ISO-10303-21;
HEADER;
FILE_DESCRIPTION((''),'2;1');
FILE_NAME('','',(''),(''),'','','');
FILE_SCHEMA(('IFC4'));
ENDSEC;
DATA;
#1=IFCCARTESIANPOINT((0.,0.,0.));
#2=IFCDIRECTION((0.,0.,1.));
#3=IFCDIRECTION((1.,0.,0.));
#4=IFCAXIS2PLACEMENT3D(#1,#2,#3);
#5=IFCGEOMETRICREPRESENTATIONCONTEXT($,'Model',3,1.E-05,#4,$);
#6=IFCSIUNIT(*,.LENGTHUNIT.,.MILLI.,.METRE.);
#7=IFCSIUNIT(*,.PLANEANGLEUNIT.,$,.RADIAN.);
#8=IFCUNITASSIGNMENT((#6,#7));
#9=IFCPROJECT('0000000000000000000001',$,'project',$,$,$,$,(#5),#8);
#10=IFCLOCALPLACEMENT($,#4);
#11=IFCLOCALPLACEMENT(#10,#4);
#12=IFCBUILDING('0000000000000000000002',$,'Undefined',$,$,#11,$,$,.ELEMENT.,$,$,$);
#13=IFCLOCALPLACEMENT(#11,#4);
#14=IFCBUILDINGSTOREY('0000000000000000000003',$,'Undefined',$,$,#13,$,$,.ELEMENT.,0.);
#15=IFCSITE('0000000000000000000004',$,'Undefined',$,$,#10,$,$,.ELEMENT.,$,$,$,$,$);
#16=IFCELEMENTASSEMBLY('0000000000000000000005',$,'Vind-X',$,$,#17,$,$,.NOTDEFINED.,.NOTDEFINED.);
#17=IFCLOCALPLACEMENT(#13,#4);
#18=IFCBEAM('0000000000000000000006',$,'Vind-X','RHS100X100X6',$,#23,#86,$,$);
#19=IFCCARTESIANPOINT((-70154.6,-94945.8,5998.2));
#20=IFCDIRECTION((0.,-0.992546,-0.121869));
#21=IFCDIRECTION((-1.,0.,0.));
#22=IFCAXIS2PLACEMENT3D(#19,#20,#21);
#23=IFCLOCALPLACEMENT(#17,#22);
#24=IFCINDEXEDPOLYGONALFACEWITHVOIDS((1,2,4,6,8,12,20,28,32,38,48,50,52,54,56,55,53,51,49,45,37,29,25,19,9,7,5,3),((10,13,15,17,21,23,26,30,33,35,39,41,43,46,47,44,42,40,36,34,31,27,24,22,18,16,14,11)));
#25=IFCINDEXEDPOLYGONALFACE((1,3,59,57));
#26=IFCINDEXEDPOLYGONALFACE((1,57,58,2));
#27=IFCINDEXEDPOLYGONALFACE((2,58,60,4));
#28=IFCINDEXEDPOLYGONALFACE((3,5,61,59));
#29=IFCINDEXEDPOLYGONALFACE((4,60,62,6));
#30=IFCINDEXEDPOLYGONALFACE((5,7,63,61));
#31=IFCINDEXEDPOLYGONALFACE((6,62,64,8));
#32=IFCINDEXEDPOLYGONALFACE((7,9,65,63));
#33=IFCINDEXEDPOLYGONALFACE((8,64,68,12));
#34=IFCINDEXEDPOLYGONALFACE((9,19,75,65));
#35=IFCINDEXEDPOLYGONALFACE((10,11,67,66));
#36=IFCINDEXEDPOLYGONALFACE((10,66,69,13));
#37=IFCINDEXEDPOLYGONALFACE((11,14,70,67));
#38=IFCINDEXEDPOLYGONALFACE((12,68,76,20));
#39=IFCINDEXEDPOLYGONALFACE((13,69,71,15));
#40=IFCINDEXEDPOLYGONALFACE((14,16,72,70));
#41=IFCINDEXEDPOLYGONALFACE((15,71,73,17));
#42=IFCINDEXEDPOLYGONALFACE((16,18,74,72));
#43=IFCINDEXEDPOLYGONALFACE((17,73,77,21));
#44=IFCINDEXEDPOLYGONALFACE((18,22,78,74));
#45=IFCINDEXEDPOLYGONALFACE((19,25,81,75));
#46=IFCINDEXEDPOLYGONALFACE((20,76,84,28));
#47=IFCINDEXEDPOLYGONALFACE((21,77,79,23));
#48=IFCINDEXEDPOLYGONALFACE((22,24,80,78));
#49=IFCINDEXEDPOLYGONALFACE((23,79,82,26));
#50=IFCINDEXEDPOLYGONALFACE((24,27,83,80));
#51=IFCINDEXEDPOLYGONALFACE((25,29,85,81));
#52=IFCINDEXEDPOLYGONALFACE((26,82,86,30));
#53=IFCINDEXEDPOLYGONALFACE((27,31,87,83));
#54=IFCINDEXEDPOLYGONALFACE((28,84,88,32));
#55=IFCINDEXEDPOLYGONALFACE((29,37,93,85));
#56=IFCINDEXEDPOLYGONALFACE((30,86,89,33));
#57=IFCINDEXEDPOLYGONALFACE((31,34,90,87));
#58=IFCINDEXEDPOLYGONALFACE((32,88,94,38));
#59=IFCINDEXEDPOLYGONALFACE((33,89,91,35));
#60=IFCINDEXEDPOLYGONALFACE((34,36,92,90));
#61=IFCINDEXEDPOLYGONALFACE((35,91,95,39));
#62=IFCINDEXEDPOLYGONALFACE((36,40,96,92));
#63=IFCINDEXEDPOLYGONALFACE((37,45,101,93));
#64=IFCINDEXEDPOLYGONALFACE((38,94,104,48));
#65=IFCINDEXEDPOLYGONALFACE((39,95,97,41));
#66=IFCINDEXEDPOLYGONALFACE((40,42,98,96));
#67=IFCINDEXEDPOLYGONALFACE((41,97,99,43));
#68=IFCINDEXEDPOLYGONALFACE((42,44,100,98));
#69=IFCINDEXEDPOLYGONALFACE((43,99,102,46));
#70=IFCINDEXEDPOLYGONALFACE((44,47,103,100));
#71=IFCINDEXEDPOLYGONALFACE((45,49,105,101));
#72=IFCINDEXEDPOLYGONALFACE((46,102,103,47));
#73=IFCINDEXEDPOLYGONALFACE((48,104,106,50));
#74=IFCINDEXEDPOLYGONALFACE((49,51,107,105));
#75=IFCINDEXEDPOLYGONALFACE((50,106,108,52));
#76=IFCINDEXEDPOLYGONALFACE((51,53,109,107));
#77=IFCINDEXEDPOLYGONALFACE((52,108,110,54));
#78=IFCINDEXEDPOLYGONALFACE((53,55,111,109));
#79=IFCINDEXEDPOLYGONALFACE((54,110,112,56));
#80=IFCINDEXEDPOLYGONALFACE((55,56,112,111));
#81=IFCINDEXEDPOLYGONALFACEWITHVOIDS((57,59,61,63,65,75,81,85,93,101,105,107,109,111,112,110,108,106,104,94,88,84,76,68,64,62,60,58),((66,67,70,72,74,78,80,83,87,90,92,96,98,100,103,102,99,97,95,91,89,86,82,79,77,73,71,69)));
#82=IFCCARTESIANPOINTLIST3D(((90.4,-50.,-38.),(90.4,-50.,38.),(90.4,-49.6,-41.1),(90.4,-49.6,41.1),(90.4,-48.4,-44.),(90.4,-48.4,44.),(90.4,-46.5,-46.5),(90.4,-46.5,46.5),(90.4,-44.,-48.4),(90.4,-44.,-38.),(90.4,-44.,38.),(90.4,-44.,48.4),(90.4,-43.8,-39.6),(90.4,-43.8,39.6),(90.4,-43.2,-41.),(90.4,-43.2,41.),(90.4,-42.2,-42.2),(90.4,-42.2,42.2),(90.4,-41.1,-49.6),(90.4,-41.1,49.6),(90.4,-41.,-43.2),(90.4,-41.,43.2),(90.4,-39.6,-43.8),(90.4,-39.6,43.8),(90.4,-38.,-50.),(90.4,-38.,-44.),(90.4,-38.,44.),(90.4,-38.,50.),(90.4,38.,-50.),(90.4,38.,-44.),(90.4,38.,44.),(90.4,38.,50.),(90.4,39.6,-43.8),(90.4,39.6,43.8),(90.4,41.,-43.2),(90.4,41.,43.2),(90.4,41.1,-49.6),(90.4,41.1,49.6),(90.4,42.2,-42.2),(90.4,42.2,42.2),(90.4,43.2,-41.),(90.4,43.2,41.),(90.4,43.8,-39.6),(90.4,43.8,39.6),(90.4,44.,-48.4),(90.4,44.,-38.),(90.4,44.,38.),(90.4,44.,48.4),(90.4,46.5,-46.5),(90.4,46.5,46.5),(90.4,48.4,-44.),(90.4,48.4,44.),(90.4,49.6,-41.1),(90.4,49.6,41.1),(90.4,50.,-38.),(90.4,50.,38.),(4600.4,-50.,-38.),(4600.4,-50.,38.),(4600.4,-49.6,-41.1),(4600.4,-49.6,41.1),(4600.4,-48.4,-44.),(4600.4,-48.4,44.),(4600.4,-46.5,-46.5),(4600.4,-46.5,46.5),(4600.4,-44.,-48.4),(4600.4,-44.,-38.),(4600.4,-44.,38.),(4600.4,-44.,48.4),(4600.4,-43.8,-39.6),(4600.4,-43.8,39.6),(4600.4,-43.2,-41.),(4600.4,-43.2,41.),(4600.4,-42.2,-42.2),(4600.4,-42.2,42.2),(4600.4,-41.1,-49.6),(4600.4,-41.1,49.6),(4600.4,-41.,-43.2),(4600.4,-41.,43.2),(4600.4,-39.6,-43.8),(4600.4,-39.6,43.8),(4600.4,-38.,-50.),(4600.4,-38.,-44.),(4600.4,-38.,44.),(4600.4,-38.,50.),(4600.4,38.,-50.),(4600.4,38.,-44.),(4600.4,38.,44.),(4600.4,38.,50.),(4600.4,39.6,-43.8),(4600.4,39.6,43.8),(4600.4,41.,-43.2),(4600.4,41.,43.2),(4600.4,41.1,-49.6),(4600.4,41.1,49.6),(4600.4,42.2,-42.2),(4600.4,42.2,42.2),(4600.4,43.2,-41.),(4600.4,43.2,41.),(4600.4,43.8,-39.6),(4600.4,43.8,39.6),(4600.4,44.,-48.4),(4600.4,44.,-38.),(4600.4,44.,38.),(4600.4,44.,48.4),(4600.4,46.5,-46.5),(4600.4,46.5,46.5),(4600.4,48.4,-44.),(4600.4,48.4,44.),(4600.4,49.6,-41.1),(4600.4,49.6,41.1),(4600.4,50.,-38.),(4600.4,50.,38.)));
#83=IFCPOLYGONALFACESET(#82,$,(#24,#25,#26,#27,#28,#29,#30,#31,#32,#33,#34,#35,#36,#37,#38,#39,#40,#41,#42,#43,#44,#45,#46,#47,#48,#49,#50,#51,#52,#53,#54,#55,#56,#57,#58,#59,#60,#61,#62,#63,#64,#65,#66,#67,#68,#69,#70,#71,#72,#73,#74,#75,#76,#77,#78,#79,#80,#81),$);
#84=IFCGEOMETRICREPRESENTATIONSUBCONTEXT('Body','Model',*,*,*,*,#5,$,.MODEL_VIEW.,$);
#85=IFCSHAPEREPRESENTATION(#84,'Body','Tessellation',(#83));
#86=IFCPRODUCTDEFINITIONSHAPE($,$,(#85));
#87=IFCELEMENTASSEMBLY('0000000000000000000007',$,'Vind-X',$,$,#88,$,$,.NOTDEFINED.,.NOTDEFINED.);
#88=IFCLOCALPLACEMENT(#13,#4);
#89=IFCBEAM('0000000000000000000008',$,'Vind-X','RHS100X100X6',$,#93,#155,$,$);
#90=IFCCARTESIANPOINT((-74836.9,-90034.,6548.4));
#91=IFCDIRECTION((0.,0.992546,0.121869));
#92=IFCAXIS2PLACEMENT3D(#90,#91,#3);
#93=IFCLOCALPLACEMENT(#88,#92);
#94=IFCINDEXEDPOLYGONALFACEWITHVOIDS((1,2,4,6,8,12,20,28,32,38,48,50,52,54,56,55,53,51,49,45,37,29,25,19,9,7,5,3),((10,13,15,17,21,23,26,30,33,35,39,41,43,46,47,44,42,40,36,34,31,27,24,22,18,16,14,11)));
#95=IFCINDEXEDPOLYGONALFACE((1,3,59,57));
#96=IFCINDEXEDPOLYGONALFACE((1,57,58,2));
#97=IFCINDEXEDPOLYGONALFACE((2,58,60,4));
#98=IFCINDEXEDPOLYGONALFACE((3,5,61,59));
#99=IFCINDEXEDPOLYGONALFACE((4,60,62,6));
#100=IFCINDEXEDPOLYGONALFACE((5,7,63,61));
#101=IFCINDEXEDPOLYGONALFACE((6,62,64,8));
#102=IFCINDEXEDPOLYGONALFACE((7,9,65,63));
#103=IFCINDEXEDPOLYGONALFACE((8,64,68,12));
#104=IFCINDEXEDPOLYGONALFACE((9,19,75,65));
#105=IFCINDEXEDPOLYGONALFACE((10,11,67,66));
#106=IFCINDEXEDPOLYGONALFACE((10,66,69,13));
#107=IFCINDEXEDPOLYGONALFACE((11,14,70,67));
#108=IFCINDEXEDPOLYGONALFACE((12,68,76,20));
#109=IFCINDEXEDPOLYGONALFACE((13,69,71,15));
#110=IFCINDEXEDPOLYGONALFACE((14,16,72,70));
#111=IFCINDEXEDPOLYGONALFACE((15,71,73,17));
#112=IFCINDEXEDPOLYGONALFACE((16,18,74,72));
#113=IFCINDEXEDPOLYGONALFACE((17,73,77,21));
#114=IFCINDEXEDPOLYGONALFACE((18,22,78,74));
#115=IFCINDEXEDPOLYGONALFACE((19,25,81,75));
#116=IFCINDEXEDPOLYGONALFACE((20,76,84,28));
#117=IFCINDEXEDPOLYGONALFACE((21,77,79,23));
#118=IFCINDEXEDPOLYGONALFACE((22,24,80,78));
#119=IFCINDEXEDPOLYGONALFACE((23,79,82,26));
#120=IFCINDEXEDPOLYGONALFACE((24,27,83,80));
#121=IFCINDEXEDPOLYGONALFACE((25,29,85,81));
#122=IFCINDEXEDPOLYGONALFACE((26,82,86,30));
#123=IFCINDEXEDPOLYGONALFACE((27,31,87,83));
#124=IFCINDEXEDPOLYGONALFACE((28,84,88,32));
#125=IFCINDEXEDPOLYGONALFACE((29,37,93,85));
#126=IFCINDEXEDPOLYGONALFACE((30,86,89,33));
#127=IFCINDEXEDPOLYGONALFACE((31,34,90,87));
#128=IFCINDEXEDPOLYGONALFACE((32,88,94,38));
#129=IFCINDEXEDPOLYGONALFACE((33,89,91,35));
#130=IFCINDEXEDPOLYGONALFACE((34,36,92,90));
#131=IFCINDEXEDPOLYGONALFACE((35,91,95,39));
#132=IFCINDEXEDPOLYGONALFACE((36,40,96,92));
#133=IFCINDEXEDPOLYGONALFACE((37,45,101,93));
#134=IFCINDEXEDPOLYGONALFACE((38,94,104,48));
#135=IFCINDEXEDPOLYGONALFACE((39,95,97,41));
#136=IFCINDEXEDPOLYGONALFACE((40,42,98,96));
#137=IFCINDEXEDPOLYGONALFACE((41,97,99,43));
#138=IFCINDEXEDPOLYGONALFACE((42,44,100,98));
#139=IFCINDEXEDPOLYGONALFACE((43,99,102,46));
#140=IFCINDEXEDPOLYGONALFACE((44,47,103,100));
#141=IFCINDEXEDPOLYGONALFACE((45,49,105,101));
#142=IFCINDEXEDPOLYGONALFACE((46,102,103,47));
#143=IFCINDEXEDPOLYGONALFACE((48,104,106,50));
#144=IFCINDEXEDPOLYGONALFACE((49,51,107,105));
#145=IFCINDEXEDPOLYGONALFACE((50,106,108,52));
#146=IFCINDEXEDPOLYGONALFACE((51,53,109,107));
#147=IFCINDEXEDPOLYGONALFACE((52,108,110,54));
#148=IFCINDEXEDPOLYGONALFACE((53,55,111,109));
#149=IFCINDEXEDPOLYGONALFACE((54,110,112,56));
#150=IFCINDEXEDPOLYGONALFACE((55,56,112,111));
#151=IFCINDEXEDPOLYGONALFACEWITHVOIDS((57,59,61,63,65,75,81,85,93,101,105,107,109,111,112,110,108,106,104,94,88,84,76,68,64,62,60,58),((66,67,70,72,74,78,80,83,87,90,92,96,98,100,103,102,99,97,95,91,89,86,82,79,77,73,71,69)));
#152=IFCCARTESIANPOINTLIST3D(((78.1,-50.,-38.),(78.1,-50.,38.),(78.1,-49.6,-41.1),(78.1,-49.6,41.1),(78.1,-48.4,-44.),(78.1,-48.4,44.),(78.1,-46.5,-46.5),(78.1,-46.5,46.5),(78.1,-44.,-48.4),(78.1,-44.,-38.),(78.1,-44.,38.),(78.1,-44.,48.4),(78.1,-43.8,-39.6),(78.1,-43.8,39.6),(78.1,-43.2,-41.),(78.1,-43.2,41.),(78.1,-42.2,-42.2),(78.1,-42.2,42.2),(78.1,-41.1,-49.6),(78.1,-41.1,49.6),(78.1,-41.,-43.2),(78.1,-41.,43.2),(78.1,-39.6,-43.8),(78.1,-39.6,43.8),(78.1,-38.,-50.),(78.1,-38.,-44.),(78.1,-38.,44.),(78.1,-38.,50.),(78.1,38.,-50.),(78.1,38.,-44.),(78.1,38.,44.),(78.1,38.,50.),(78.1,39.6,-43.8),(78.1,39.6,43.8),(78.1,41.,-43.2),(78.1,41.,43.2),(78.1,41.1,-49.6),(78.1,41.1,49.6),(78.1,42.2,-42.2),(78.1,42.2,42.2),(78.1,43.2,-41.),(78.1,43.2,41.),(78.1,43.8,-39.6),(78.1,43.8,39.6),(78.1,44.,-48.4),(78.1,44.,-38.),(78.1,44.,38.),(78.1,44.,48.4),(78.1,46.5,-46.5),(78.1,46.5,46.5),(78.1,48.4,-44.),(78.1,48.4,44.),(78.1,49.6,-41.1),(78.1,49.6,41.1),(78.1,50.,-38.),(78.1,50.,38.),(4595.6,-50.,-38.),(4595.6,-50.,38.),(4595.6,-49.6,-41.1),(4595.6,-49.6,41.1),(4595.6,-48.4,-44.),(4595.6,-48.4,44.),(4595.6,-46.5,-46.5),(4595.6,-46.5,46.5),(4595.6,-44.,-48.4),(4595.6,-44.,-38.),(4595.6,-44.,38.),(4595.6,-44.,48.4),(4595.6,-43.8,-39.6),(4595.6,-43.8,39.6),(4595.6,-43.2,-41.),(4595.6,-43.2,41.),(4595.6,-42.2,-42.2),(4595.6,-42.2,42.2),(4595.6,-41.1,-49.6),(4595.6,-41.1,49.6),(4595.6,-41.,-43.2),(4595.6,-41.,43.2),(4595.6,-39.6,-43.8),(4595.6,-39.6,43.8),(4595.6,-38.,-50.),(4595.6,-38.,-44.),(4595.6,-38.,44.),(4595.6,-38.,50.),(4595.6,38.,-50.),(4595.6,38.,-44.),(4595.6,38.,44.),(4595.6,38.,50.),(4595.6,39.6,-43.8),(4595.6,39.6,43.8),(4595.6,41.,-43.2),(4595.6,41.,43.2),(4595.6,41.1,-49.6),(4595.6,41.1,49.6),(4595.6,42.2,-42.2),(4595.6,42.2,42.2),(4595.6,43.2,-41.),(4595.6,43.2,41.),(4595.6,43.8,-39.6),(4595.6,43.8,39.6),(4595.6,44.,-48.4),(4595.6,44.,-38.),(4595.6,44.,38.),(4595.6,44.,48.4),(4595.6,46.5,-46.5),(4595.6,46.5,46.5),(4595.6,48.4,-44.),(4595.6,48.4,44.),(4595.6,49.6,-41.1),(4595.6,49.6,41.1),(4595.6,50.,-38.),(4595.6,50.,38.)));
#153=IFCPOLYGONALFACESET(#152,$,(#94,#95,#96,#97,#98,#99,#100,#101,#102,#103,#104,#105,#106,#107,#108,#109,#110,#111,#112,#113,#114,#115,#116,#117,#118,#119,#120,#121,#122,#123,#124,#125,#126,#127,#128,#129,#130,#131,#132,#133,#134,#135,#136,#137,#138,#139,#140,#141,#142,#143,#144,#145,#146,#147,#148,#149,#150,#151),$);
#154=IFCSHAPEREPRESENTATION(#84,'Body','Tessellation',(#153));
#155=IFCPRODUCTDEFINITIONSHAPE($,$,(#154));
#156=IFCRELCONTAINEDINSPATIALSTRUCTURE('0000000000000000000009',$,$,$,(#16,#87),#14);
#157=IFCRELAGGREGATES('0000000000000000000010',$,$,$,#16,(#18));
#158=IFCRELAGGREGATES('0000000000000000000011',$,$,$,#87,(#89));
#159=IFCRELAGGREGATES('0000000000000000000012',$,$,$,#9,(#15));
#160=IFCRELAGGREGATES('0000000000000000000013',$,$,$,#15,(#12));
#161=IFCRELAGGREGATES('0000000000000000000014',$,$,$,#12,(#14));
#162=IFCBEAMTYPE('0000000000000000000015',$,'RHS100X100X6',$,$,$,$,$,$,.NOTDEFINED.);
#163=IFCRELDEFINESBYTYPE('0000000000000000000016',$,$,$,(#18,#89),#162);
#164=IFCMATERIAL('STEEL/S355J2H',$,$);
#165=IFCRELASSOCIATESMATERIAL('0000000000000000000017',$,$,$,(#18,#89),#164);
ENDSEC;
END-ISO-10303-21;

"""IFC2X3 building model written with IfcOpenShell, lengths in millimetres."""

from ifc_helpers import new_model, si_unit, frame, origin_with_axes, origin_2d_with_axis, place, context, subcontext, project, spatial, hollow_rectangle, extrude, clip, halfspace, material, type_object, element, aggregate, save


model = new_model("IFC2X3")

# Units and contexts
model_context = context("Model", 3, precision=1e-05, world=origin_with_axes())
body_context = subcontext(model_context, "Body", "Model", "MODEL_VIEW")
ifc_project = project(units=[si_unit("LENGTHUNIT", "METRE", prefix="MILLI"), si_unit("PLANEANGLEUNIT", "RADIAN")], contexts=[model_context])

# Site, building, storey
site_placement = place(None, origin_with_axes())
site = spatial("IfcSite", under=ifc_project, at=site_placement, Name="Undefined", CompositionType="ELEMENT")
building_placement = place(site_placement, origin_with_axes())
building = spatial("IfcBuilding", under=site, at=building_placement, Name="Undefined", CompositionType="ELEMENT")
storey_placement = place(building_placement, origin_with_axes())
storey = spatial("IfcBuildingStorey", under=building, at=storey_placement, Name="Undefined", CompositionType="ELEMENT", Elevation=0.0)

# Element assemblies, beams
assembly_1_placement = place(storey_placement, origin_with_axes())
assembly_1 = element("IfcElementAssembly", 1, at=assembly_1_placement, inside=storey, Name="Vind-X", AssemblyPlace="NOTDEFINED", PredefinedType="NOTDEFINED")
ifc_material_1 = material(Name="STEEL/S355J2H")
beam_type = type_object("IfcBeamType", Name="RHS100X100X6", PredefinedType="NOTDEFINED")
beam_1_placement = place(assembly_1_placement, frame((-70154.6, -94945.8, 5998.2), z_axis=(0.0, -0.992546, -0.121869), x_axis=(-1.0, 0.0, 0.0)))
beam_1 = element("IfcBeam", 2, at=beam_1_placement, type_object=beam_type, material=ifc_material_1, Name="Vind-X", Description="RHS100X100X6", context=body_context, shape_type="Clipping", body=[
    clip(clip(extrude(hollow_rectangle(XDim=100.0, YDim=100.0, WallThickness=6.0, InnerFilletRadius=6.0, OuterFilletRadius=12.0, at=origin_2d_with_axis()), frame((4690.0, 0.0, 0.0), z_axis=(-1.0, 0.0, 0.0), x_axis=(0.0, -1.0, 0.0)), (0.0, 0.0, 1.0), 4690.0), halfspace(frame((4600.4, 22.5, 0.0), z_axis=(-1.0, 0.0, 0.0), x_axis=(0.0, 0.0, 1.0)), True)), halfspace(frame((90.4, 22.5, 0.0), z_axis=(1.0, 0.0, 0.0), x_axis=(0.0, 0.0, -1.0)), True)),
])
assembly_2_placement = place(storey_placement, origin_with_axes())
assembly_2 = element("IfcElementAssembly", 3, at=assembly_2_placement, inside=storey, Name="Vind-X", AssemblyPlace="NOTDEFINED", PredefinedType="NOTDEFINED")
beam_2_placement = place(assembly_2_placement, frame((-74836.9, -90034.0, 6548.4), z_axis=(0.0, 0.992546, 0.121869), x_axis=(1.0, 0.0, 0.0)))
beam_2 = element("IfcBeam", 4, at=beam_2_placement, type_object=beam_type, material=ifc_material_1, Name="Vind-X", Description="RHS100X100X6", context=body_context, shape_type="Clipping", body=[
    clip(clip(extrude(hollow_rectangle(XDim=100.0, YDim=100.0, WallThickness=6.0, InnerFilletRadius=6.0, OuterFilletRadius=12.0, at=origin_2d_with_axis()), frame((4674.6, 0.0, 0.0), z_axis=(-1.0, 0.0, 0.0), x_axis=(0.0, -1.0, 0.0)), (0.0, 0.0, 1.0), 4674.6), halfspace(frame((4595.6, 22.5, 0.0), z_axis=(-1.0, 0.0, 0.0), x_axis=(0.0, 0.0, 1.0)), True)), halfspace(frame((78.1, 22.5, 0.0), z_axis=(1.0, 0.0, 0.0), x_axis=(0.0, 0.0, -1.0)), True)),
])

aggregate(assembly_1, [beam_1])

aggregate(assembly_2, [beam_2])

save(model, "model.ifc")
